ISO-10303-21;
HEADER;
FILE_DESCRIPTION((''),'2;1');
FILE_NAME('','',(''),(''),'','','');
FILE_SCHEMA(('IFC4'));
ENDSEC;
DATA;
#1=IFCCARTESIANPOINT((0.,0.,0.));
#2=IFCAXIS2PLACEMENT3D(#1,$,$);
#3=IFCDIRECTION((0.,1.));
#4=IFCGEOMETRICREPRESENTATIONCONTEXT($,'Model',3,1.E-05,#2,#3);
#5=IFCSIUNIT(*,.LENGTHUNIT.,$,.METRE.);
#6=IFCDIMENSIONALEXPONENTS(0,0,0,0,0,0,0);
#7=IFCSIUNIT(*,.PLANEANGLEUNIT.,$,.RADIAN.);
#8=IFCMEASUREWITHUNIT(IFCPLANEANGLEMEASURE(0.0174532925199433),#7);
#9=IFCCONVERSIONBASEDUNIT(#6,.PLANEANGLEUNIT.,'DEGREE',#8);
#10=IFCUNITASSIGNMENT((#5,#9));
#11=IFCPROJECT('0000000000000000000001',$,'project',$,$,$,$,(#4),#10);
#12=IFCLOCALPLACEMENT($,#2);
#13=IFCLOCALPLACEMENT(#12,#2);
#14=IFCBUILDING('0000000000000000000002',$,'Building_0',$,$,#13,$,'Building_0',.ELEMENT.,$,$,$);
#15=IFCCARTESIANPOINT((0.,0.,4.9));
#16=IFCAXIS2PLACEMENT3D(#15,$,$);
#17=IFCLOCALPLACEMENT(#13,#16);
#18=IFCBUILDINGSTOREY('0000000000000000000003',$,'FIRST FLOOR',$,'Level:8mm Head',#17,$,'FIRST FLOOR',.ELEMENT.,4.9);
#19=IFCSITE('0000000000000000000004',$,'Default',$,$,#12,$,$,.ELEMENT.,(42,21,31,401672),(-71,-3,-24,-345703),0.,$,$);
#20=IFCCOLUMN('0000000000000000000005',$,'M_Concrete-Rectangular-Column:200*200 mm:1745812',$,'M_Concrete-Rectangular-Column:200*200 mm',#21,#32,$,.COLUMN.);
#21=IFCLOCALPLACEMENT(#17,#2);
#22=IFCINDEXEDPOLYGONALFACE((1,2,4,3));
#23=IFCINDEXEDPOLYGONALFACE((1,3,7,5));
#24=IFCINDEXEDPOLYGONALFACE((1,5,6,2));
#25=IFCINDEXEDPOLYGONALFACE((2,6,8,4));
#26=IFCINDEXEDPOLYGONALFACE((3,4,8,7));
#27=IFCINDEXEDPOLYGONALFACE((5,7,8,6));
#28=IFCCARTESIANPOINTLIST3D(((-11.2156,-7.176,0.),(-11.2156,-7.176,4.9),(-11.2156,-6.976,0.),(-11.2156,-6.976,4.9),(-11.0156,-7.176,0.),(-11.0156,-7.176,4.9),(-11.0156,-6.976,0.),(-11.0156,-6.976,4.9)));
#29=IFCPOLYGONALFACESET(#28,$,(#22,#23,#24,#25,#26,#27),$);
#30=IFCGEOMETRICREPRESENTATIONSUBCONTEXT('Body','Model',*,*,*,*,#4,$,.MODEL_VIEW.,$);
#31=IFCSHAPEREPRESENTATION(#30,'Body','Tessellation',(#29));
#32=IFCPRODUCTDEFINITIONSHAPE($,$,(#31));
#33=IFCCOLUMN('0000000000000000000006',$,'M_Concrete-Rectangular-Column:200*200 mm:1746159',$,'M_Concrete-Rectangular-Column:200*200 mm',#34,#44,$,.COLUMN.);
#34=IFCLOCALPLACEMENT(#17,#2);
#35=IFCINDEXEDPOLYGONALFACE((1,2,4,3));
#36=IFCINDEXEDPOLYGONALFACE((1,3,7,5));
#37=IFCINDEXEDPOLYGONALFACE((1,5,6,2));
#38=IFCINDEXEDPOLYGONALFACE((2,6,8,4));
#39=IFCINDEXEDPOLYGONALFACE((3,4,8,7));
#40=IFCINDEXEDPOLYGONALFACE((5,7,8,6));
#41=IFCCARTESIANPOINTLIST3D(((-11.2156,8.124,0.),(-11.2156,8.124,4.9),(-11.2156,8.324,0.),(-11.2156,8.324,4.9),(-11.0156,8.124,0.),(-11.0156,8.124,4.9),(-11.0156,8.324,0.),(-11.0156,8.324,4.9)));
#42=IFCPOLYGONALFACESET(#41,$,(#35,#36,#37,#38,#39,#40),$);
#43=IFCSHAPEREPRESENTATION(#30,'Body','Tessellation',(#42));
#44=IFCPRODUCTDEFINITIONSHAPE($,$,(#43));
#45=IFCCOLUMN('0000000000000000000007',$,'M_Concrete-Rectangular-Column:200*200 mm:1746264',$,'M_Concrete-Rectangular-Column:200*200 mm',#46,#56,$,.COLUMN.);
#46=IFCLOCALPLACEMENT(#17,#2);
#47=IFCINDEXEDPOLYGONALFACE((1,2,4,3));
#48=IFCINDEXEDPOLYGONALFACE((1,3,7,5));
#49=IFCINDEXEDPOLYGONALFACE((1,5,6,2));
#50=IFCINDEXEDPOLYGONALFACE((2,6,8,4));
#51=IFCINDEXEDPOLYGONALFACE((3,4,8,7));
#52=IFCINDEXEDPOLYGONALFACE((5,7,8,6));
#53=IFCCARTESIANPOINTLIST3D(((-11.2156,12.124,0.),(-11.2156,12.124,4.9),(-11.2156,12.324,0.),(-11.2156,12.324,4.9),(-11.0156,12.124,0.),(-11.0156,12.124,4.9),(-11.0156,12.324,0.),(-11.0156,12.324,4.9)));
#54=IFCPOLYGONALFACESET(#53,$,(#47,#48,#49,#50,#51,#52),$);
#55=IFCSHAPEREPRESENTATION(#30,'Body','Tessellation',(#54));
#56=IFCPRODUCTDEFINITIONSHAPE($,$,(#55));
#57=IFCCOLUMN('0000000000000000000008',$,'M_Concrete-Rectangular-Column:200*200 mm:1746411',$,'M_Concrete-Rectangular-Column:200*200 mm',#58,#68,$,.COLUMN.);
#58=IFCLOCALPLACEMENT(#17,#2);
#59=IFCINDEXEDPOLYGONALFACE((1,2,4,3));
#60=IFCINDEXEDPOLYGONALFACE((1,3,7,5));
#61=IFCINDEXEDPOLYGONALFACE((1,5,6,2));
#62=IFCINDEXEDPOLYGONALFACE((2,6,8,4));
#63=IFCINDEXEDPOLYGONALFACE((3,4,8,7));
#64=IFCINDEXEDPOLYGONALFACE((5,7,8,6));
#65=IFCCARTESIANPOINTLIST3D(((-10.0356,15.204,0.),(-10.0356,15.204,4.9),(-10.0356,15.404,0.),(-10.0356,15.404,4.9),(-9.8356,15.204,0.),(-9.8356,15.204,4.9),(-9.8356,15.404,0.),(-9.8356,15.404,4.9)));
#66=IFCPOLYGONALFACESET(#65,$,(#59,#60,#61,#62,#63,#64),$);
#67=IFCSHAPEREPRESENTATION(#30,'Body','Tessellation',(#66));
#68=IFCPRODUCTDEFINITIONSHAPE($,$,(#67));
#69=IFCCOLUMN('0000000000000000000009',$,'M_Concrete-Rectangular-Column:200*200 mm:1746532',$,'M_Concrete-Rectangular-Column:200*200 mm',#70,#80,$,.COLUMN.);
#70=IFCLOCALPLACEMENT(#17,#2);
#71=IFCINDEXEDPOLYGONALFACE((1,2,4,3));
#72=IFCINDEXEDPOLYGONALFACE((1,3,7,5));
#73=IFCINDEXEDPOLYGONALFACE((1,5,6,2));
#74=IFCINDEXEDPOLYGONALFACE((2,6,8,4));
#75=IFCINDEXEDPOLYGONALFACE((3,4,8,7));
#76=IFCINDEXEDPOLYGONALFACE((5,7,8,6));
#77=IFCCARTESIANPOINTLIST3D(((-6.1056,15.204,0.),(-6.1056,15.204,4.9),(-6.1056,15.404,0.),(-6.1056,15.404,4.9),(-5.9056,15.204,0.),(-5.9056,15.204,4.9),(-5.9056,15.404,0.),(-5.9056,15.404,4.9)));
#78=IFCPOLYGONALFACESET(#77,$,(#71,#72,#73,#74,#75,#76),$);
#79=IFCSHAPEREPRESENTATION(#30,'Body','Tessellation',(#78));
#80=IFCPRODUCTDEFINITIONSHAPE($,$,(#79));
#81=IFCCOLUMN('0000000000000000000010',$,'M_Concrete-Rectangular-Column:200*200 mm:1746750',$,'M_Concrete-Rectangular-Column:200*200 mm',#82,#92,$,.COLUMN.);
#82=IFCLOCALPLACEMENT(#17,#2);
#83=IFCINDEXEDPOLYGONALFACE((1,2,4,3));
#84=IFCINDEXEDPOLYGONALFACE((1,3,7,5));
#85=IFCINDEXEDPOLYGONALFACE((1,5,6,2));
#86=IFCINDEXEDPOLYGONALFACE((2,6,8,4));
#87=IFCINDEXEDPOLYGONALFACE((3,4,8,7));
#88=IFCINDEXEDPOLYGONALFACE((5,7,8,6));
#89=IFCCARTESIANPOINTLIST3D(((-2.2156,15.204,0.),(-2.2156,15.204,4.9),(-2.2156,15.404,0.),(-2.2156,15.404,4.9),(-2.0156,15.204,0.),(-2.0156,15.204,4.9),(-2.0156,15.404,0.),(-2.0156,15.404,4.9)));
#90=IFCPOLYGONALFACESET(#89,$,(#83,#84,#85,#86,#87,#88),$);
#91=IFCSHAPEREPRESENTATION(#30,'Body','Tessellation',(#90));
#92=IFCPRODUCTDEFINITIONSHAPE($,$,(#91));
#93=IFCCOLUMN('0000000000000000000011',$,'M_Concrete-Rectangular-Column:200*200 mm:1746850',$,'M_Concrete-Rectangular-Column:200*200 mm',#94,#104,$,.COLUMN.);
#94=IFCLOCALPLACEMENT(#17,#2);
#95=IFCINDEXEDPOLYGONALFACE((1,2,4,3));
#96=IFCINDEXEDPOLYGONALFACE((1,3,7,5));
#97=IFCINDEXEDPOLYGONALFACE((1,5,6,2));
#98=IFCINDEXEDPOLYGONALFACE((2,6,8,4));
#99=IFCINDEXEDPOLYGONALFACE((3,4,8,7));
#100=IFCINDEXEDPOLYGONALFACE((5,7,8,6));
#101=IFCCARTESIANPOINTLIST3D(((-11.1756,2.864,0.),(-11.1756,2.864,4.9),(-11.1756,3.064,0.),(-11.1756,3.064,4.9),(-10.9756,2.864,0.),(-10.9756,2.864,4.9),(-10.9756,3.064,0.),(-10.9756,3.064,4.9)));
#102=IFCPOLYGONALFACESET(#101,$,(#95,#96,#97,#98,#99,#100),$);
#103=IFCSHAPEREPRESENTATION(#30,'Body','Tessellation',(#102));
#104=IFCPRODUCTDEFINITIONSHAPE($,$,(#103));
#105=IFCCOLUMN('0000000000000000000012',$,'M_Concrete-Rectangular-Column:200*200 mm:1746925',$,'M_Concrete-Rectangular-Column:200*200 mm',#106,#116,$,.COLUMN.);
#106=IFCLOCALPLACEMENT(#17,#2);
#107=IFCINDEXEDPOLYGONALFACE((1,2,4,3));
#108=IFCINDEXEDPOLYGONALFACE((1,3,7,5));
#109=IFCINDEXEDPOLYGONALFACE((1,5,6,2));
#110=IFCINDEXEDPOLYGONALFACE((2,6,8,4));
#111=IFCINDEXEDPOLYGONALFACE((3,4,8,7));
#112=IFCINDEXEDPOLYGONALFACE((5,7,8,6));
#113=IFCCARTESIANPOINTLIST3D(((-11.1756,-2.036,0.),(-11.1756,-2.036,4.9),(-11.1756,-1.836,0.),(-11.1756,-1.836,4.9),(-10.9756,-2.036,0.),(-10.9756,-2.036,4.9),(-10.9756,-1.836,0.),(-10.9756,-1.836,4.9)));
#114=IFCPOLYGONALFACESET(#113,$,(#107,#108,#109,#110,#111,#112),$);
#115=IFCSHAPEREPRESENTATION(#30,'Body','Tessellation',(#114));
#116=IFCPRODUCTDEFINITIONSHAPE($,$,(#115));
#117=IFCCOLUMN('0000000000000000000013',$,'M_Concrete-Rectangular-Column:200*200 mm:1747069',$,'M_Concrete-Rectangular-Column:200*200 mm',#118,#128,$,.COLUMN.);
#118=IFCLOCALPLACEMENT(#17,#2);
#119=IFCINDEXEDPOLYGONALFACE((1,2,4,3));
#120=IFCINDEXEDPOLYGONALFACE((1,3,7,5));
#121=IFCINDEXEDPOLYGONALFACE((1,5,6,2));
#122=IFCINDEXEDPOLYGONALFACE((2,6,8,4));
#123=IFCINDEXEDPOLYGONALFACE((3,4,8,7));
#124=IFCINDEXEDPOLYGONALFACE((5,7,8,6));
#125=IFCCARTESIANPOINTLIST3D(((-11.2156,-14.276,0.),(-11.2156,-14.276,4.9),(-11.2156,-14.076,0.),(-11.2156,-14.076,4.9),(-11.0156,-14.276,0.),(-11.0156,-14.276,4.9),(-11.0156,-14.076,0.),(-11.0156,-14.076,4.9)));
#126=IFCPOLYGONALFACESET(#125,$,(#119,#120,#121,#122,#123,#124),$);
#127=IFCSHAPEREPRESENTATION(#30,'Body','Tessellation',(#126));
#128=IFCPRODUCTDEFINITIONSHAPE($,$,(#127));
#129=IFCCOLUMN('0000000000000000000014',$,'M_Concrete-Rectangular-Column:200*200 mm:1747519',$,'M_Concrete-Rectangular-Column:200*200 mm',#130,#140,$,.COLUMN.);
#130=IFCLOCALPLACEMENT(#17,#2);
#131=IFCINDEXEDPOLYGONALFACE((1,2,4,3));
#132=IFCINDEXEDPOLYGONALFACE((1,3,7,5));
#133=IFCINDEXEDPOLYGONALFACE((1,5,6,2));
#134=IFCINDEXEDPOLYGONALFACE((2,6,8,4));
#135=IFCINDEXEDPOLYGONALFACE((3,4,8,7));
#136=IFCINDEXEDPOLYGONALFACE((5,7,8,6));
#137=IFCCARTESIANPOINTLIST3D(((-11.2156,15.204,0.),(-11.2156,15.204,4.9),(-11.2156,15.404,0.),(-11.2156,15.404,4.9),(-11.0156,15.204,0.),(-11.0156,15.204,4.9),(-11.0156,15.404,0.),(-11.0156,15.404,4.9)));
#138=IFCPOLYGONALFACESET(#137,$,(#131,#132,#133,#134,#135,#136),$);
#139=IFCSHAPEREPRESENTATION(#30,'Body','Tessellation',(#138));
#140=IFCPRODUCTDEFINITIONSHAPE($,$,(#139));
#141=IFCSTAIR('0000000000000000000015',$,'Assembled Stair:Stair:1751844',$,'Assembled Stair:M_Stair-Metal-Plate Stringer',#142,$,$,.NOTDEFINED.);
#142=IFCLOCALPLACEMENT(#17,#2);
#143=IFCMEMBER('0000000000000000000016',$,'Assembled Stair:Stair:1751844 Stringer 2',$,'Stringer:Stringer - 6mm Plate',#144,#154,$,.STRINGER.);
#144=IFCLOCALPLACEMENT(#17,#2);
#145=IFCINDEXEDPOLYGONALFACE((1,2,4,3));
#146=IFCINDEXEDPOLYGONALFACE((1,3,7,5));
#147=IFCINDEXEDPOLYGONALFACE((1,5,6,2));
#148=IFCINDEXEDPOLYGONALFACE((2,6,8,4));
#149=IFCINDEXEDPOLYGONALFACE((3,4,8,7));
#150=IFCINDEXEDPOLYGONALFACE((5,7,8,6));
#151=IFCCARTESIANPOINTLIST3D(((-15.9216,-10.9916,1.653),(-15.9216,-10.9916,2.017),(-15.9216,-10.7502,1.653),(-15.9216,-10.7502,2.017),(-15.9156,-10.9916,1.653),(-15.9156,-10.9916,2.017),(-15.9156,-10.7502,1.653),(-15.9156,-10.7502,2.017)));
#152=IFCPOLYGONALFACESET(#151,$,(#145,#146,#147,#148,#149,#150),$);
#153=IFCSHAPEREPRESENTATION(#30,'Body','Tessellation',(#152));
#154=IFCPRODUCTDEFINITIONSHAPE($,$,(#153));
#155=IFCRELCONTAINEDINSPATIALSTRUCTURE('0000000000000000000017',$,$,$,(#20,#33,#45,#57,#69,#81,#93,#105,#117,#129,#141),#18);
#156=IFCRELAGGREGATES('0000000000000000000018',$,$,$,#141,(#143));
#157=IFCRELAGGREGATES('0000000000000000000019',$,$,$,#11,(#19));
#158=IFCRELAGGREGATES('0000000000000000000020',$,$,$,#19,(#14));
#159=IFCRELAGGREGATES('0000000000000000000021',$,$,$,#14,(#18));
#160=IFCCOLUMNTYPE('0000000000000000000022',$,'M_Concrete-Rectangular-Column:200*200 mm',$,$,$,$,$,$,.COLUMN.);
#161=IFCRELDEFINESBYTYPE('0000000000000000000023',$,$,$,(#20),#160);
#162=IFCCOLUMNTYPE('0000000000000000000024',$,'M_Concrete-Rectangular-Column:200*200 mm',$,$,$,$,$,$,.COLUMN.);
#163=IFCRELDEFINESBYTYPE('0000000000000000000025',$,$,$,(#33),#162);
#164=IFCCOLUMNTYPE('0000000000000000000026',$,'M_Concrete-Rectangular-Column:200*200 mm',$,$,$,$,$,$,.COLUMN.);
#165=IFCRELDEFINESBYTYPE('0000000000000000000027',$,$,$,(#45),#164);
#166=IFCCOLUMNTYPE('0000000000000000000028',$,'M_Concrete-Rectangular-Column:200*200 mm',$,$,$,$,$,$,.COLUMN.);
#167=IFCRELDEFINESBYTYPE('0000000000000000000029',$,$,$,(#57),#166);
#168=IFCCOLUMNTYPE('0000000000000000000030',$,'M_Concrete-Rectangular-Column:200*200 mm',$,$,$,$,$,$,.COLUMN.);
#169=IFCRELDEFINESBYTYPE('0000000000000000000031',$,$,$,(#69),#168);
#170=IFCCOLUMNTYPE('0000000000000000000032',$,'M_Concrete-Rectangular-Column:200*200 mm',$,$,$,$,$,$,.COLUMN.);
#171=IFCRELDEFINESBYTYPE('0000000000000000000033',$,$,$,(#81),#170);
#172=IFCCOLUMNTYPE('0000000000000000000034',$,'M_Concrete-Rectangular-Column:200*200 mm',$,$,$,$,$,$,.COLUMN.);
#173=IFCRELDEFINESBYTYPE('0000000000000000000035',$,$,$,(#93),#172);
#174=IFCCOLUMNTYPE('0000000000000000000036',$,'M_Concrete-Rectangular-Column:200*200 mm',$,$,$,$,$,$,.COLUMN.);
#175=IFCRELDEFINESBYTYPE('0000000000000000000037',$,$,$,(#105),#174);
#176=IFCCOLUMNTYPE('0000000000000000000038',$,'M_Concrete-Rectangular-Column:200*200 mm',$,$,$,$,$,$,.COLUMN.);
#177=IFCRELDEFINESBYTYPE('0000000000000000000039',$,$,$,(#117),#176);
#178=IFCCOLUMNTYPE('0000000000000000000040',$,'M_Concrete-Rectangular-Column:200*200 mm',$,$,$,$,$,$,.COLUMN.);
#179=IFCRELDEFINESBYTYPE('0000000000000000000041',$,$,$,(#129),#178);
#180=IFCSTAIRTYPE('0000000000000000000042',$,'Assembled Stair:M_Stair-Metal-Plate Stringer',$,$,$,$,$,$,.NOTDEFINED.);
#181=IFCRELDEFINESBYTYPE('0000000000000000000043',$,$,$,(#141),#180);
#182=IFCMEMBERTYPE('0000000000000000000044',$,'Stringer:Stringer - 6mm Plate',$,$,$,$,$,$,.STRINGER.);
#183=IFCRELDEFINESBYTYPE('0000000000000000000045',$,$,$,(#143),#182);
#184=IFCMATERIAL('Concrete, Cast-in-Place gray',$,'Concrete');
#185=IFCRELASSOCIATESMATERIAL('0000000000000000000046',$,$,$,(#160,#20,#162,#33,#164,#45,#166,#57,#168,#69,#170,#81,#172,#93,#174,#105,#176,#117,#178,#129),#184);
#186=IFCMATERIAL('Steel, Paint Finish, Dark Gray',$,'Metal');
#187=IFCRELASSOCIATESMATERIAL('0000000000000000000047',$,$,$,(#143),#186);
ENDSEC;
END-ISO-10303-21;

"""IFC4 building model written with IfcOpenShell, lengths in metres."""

from ifc_helpers import new_model, entity, si_unit, converted_unit, direction, frame, origin, place, context, subcontext, project, spatial, indexed_curve, outline, extrude, source, transform, mapped, material, type_object, type_shapes, element, aggregate, save


model = new_model("IFC4")

# Units and contexts
model_context = context("Model", 3, precision=1e-05, world=origin(), true_north=direction((0.0, 1.0)))
body_context = subcontext(model_context, "Body", "Model", "MODEL_VIEW")
ifc_project = project(units=[si_unit("LENGTHUNIT", "METRE"), converted_unit("PLANEANGLEUNIT", "DEGREE", entity("IfcPlaneAngleMeasure", 0.0174532925199433), si_unit("PLANEANGLEUNIT", "RADIAN"), dimensions=[0, 0, 0, 0, 0, 0, 0])], contexts=[model_context])

# Site, building, storey
site_placement = place(None, origin())
site = spatial("IfcSite", under=ifc_project, at=site_placement, Name="Default", CompositionType="ELEMENT", RefLatitude=(42, 21, 31, 401672), RefLongitude=(-71, -3, -24, -345703), RefElevation=0.0)
building_placement = place(site_placement, origin())
building = spatial("IfcBuilding", under=site, at=building_placement, Name="Building_0", LongName="Building_0", CompositionType="ELEMENT")
storey_placement = place(building_placement, frame((0.0, 0.0, 4.9)))
storey = spatial("IfcBuildingStorey", under=building, at=storey_placement, Name="FIRST FLOOR", ObjectType="Level:8mm Head", LongName="FIRST FLOOR", CompositionType="ELEMENT", Elevation=4.9)

# Columns
ifc_material_1 = material(Name="Concrete, Cast-in-Place gray", Category="Concrete")
column_type_1 = type_object("IfcColumnType", Name="M_Concrete-Rectangular-Column:200*200 mm", PredefinedType="COLUMN", material=ifc_material_1)
shared_shape_1 = source(origin(), body_context, "Body", "SweptSolid", [
    extrude(outline(indexed_curve([(-0.1, -0.1), (0.1, -0.1), (0.1, 0.1), (-0.1, 0.1), (-0.1, -0.1)], self_intersect=False)), frame((-11.1156, -7.076, 4.9), z_axis=(0.0, 0.0, 1.0), x_axis=(-1.0, 0.0, 0.0)), (0.0, 0.0, 1.0), 4.9),
])
type_shapes(column_type_1, [shared_shape_1])
column_1_placement = place(storey_placement, frame((0.0, 0.0, -4.9)))
element("IfcColumn", 1, at=column_1_placement, inside=storey, type_object=column_type_1, material=ifc_material_1, Name="M_Concrete-Rectangular-Column:200*200 mm:1745812", ObjectType="M_Concrete-Rectangular-Column:200*200 mm", PredefinedType="COLUMN", context=body_context, shape_type="MappedRepresentation", body=[
    mapped(shared_shape_1, transform((0.0, 0.0, 0.0), scale=1.0)),
])
column_type_2 = type_object("IfcColumnType", Name="M_Concrete-Rectangular-Column:200*200 mm", PredefinedType="COLUMN", material=ifc_material_1)
shared_shape_2 = source(origin(), body_context, "Body", "SweptSolid", [
    extrude(outline(indexed_curve([(-0.1, -0.1), (0.1, -0.1), (0.1, 0.1), (-0.1, 0.1), (-0.1, -0.1)], self_intersect=False)), frame((-11.1156, 8.224, 4.9), z_axis=(0.0, 0.0, 1.0), x_axis=(-1.0, 0.0, 0.0)), (0.0, 0.0, 1.0), 4.9),
])
type_shapes(column_type_2, [shared_shape_2])
column_2_placement = place(storey_placement, frame((0.0, 0.0, -4.9)))
element("IfcColumn", 2, at=column_2_placement, inside=storey, type_object=column_type_2, material=ifc_material_1, Name="M_Concrete-Rectangular-Column:200*200 mm:1746159", ObjectType="M_Concrete-Rectangular-Column:200*200 mm", PredefinedType="COLUMN", context=body_context, shape_type="MappedRepresentation", body=[
    mapped(shared_shape_2, transform((0.0, 0.0, 0.0), scale=1.0)),
])
column_type_3 = type_object("IfcColumnType", Name="M_Concrete-Rectangular-Column:200*200 mm", PredefinedType="COLUMN", material=ifc_material_1)
shared_shape_3 = source(origin(), body_context, "Body", "SweptSolid", [
    extrude(outline(indexed_curve([(-0.1, -0.1), (0.1, -0.1), (0.1, 0.1), (-0.1, 0.1), (-0.1, -0.1)], self_intersect=False)), frame((-11.1156, 12.224, 4.9), z_axis=(0.0, 0.0, 1.0), x_axis=(-1.0, 0.0, 0.0)), (0.0, 0.0, 1.0), 4.9),
])
type_shapes(column_type_3, [shared_shape_3])
column_3_placement = place(storey_placement, frame((0.0, 0.0, -4.9)))
element("IfcColumn", 3, at=column_3_placement, inside=storey, type_object=column_type_3, material=ifc_material_1, Name="M_Concrete-Rectangular-Column:200*200 mm:1746264", ObjectType="M_Concrete-Rectangular-Column:200*200 mm", PredefinedType="COLUMN", context=body_context, shape_type="MappedRepresentation", body=[
    mapped(shared_shape_3, transform((0.0, 0.0, 0.0), scale=1.0)),
])
column_type_4 = type_object("IfcColumnType", Name="M_Concrete-Rectangular-Column:200*200 mm", PredefinedType="COLUMN", material=ifc_material_1)
shared_shape_4 = source(origin(), body_context, "Body", "SweptSolid", [
    extrude(outline(indexed_curve([(-0.1, -0.1), (0.1, -0.1), (0.1, 0.1), (-0.1, 0.1), (-0.1, -0.1)], self_intersect=False)), frame((-9.9356, 15.304, 4.9), z_axis=(0.0, 0.0, 1.0), x_axis=(-1.0, 0.0, 0.0)), (0.0, 0.0, 1.0), 4.9),
])
type_shapes(column_type_4, [shared_shape_4])
column_4_placement = place(storey_placement, frame((0.0, 0.0, -4.9)))
element("IfcColumn", 4, at=column_4_placement, inside=storey, type_object=column_type_4, material=ifc_material_1, Name="M_Concrete-Rectangular-Column:200*200 mm:1746411", ObjectType="M_Concrete-Rectangular-Column:200*200 mm", PredefinedType="COLUMN", context=body_context, shape_type="MappedRepresentation", body=[
    mapped(shared_shape_4, transform((0.0, 0.0, 0.0), scale=1.0)),
])
column_type_5 = type_object("IfcColumnType", Name="M_Concrete-Rectangular-Column:200*200 mm", PredefinedType="COLUMN", material=ifc_material_1)
shared_shape_5 = source(origin(), body_context, "Body", "SweptSolid", [
    extrude(outline(indexed_curve([(-0.1, -0.1), (0.1, -0.1), (0.1, 0.1), (-0.1, 0.1), (-0.1, -0.1)], self_intersect=False)), frame((-6.0056, 15.304, 4.9), z_axis=(0.0, 0.0, 1.0), x_axis=(-1.0, 0.0, 0.0)), (0.0, 0.0, 1.0), 4.9),
])
type_shapes(column_type_5, [shared_shape_5])
column_5_placement = place(storey_placement, frame((0.0, 0.0, -4.9)))
element("IfcColumn", 5, at=column_5_placement, inside=storey, type_object=column_type_5, material=ifc_material_1, Name="M_Concrete-Rectangular-Column:200*200 mm:1746532", ObjectType="M_Concrete-Rectangular-Column:200*200 mm", PredefinedType="COLUMN", context=body_context, shape_type="MappedRepresentation", body=[
    mapped(shared_shape_5, transform((0.0, 0.0, 0.0), scale=1.0)),
])
column_type_6 = type_object("IfcColumnType", Name="M_Concrete-Rectangular-Column:200*200 mm", PredefinedType="COLUMN", material=ifc_material_1)
shared_shape_6 = source(origin(), body_context, "Body", "SweptSolid", [
    extrude(outline(indexed_curve([(-0.1, -0.1), (0.1, -0.1), (0.1, 0.1), (-0.1, 0.1), (-0.1, -0.1)], self_intersect=False)), frame((-2.1156, 15.304, 4.9), z_axis=(0.0, 0.0, 1.0), x_axis=(-1.0, 0.0, 0.0)), (0.0, 0.0, 1.0), 4.9),
])
type_shapes(column_type_6, [shared_shape_6])
column_6_placement = place(storey_placement, frame((0.0, 0.0, -4.9)))
element("IfcColumn", 6, at=column_6_placement, inside=storey, type_object=column_type_6, material=ifc_material_1, Name="M_Concrete-Rectangular-Column:200*200 mm:1746750", ObjectType="M_Concrete-Rectangular-Column:200*200 mm", PredefinedType="COLUMN", context=body_context, shape_type="MappedRepresentation", body=[
    mapped(shared_shape_6, transform((0.0, 0.0, 0.0), scale=1.0)),
])
column_type_7 = type_object("IfcColumnType", Name="M_Concrete-Rectangular-Column:200*200 mm", PredefinedType="COLUMN", material=ifc_material_1)
shared_shape_7 = source(origin(), body_context, "Body", "SweptSolid", [
    extrude(outline(indexed_curve([(-0.1, -0.1), (0.1, -0.1), (0.1, 0.1), (-0.1, 0.1), (-0.1, -0.1)], self_intersect=False)), frame((-11.0756, 2.964, 4.9), z_axis=(0.0, 0.0, 1.0), x_axis=(-1.0, 0.0, 0.0)), (0.0, 0.0, 1.0), 4.9),
])
type_shapes(column_type_7, [shared_shape_7])
column_7_placement = place(storey_placement, frame((0.0, 0.0, -4.9)))
element("IfcColumn", 7, at=column_7_placement, inside=storey, type_object=column_type_7, material=ifc_material_1, Name="M_Concrete-Rectangular-Column:200*200 mm:1746850", ObjectType="M_Concrete-Rectangular-Column:200*200 mm", PredefinedType="COLUMN", context=body_context, shape_type="MappedRepresentation", body=[
    mapped(shared_shape_7, transform((0.0, 0.0, 0.0), scale=1.0)),
])
column_type_8 = type_object("IfcColumnType", Name="M_Concrete-Rectangular-Column:200*200 mm", PredefinedType="COLUMN", material=ifc_material_1)
shared_shape_8 = source(origin(), body_context, "Body", "SweptSolid", [
    extrude(outline(indexed_curve([(-0.1, -0.1), (0.1, -0.1), (0.1, 0.1), (-0.1, 0.1), (-0.1, -0.1)], self_intersect=False)), frame((-11.0756, -1.936, 4.9), z_axis=(0.0, 0.0, 1.0), x_axis=(-1.0, 0.0, 0.0)), (0.0, 0.0, 1.0), 4.9),
])
type_shapes(column_type_8, [shared_shape_8])
column_8_placement = place(storey_placement, frame((0.0, 0.0, -4.9)))
element("IfcColumn", 8, at=column_8_placement, inside=storey, type_object=column_type_8, material=ifc_material_1, Name="M_Concrete-Rectangular-Column:200*200 mm:1746925", ObjectType="M_Concrete-Rectangular-Column:200*200 mm", PredefinedType="COLUMN", context=body_context, shape_type="MappedRepresentation", body=[
    mapped(shared_shape_8, transform((0.0, 0.0, 0.0), scale=1.0)),
])
column_type_9 = type_object("IfcColumnType", Name="M_Concrete-Rectangular-Column:200*200 mm", PredefinedType="COLUMN", material=ifc_material_1)
shared_shape_9 = source(origin(), body_context, "Body", "SweptSolid", [
    extrude(outline(indexed_curve([(-0.1, -0.1), (0.1, -0.1), (0.1, 0.1), (-0.1, 0.1), (-0.1, -0.1)], self_intersect=False)), frame((-11.1156, -14.176, 4.9), z_axis=(0.0, 0.0, 1.0), x_axis=(-1.0, 0.0, 0.0)), (0.0, 0.0, 1.0), 4.9),
])
type_shapes(column_type_9, [shared_shape_9])
column_9_placement = place(storey_placement, frame((0.0, 0.0, -4.9)))
element("IfcColumn", 9, at=column_9_placement, inside=storey, type_object=column_type_9, material=ifc_material_1, Name="M_Concrete-Rectangular-Column:200*200 mm:1747069", ObjectType="M_Concrete-Rectangular-Column:200*200 mm", PredefinedType="COLUMN", context=body_context, shape_type="MappedRepresentation", body=[
    mapped(shared_shape_9, transform((0.0, 0.0, 0.0), scale=1.0)),
])
column_type_10 = type_object("IfcColumnType", Name="M_Concrete-Rectangular-Column:200*200 mm", PredefinedType="COLUMN", material=ifc_material_1)
shared_shape_10 = source(origin(), body_context, "Body", "SweptSolid", [
    extrude(outline(indexed_curve([(-0.1, -0.1), (0.1, -0.1), (0.1, 0.1), (-0.1, 0.1), (-0.1, -0.1)], self_intersect=False)), frame((-11.1156, 15.304, 4.9), z_axis=(0.0, 0.0, 1.0), x_axis=(-1.0, 0.0, 0.0)), (0.0, 0.0, 1.0), 4.9),
])
type_shapes(column_type_10, [shared_shape_10])
column_10_placement = place(storey_placement, frame((0.0, 0.0, -4.9)))
element("IfcColumn", 10, at=column_10_placement, inside=storey, type_object=column_type_10, material=ifc_material_1, Name="M_Concrete-Rectangular-Column:200*200 mm:1747519", ObjectType="M_Concrete-Rectangular-Column:200*200 mm", PredefinedType="COLUMN", context=body_context, shape_type="MappedRepresentation", body=[
    mapped(shared_shape_10, transform((0.0, 0.0, 0.0), scale=1.0)),
])

# Stair, member
stair_type = type_object("IfcStairType", Name="Assembled Stair:M_Stair-Metal-Plate Stringer", PredefinedType="NOTDEFINED")
stair_placement = place(storey_placement, origin())
stair = element("IfcStair", 11, at=stair_placement, inside=storey, type_object=stair_type, Name="Assembled Stair:Stair:1751844", ObjectType="Assembled Stair:M_Stair-Metal-Plate Stringer", PredefinedType="NOTDEFINED")
ifc_material_2 = material(Name="Steel, Paint Finish, Dark Gray", Category="Metal")
member_type = type_object("IfcMemberType", Name="Stringer:Stringer - 6mm Plate", PredefinedType="STRINGER")
member_1_placement = place(stair_placement, origin())
member_1 = element("IfcMember", 12, at=member_1_placement, type_object=member_type, material=ifc_material_2, Name="Assembled Stair:Stair:1751844 Stringer 2", ObjectType="Stringer:Stringer - 6mm Plate", PredefinedType="STRINGER", context=body_context, shape_type="SweptSolid", body=[
    extrude(outline(indexed_curve([(-0.1207, -0.003), (0.1207, -0.003), (0.1207, 0.003), (-0.1207, 0.003), (-0.1207, -0.003)], self_intersect=False)), frame((-15.9186, -10.8709, 1.653), z_axis=(0.0, 0.0, 1.0), x_axis=(0.0, 1.0, 0.0)), (0.0, 0.0, 1.0), 0.364),
])
aggregate(stair, [member_1])

save(model, "model.ifc")
